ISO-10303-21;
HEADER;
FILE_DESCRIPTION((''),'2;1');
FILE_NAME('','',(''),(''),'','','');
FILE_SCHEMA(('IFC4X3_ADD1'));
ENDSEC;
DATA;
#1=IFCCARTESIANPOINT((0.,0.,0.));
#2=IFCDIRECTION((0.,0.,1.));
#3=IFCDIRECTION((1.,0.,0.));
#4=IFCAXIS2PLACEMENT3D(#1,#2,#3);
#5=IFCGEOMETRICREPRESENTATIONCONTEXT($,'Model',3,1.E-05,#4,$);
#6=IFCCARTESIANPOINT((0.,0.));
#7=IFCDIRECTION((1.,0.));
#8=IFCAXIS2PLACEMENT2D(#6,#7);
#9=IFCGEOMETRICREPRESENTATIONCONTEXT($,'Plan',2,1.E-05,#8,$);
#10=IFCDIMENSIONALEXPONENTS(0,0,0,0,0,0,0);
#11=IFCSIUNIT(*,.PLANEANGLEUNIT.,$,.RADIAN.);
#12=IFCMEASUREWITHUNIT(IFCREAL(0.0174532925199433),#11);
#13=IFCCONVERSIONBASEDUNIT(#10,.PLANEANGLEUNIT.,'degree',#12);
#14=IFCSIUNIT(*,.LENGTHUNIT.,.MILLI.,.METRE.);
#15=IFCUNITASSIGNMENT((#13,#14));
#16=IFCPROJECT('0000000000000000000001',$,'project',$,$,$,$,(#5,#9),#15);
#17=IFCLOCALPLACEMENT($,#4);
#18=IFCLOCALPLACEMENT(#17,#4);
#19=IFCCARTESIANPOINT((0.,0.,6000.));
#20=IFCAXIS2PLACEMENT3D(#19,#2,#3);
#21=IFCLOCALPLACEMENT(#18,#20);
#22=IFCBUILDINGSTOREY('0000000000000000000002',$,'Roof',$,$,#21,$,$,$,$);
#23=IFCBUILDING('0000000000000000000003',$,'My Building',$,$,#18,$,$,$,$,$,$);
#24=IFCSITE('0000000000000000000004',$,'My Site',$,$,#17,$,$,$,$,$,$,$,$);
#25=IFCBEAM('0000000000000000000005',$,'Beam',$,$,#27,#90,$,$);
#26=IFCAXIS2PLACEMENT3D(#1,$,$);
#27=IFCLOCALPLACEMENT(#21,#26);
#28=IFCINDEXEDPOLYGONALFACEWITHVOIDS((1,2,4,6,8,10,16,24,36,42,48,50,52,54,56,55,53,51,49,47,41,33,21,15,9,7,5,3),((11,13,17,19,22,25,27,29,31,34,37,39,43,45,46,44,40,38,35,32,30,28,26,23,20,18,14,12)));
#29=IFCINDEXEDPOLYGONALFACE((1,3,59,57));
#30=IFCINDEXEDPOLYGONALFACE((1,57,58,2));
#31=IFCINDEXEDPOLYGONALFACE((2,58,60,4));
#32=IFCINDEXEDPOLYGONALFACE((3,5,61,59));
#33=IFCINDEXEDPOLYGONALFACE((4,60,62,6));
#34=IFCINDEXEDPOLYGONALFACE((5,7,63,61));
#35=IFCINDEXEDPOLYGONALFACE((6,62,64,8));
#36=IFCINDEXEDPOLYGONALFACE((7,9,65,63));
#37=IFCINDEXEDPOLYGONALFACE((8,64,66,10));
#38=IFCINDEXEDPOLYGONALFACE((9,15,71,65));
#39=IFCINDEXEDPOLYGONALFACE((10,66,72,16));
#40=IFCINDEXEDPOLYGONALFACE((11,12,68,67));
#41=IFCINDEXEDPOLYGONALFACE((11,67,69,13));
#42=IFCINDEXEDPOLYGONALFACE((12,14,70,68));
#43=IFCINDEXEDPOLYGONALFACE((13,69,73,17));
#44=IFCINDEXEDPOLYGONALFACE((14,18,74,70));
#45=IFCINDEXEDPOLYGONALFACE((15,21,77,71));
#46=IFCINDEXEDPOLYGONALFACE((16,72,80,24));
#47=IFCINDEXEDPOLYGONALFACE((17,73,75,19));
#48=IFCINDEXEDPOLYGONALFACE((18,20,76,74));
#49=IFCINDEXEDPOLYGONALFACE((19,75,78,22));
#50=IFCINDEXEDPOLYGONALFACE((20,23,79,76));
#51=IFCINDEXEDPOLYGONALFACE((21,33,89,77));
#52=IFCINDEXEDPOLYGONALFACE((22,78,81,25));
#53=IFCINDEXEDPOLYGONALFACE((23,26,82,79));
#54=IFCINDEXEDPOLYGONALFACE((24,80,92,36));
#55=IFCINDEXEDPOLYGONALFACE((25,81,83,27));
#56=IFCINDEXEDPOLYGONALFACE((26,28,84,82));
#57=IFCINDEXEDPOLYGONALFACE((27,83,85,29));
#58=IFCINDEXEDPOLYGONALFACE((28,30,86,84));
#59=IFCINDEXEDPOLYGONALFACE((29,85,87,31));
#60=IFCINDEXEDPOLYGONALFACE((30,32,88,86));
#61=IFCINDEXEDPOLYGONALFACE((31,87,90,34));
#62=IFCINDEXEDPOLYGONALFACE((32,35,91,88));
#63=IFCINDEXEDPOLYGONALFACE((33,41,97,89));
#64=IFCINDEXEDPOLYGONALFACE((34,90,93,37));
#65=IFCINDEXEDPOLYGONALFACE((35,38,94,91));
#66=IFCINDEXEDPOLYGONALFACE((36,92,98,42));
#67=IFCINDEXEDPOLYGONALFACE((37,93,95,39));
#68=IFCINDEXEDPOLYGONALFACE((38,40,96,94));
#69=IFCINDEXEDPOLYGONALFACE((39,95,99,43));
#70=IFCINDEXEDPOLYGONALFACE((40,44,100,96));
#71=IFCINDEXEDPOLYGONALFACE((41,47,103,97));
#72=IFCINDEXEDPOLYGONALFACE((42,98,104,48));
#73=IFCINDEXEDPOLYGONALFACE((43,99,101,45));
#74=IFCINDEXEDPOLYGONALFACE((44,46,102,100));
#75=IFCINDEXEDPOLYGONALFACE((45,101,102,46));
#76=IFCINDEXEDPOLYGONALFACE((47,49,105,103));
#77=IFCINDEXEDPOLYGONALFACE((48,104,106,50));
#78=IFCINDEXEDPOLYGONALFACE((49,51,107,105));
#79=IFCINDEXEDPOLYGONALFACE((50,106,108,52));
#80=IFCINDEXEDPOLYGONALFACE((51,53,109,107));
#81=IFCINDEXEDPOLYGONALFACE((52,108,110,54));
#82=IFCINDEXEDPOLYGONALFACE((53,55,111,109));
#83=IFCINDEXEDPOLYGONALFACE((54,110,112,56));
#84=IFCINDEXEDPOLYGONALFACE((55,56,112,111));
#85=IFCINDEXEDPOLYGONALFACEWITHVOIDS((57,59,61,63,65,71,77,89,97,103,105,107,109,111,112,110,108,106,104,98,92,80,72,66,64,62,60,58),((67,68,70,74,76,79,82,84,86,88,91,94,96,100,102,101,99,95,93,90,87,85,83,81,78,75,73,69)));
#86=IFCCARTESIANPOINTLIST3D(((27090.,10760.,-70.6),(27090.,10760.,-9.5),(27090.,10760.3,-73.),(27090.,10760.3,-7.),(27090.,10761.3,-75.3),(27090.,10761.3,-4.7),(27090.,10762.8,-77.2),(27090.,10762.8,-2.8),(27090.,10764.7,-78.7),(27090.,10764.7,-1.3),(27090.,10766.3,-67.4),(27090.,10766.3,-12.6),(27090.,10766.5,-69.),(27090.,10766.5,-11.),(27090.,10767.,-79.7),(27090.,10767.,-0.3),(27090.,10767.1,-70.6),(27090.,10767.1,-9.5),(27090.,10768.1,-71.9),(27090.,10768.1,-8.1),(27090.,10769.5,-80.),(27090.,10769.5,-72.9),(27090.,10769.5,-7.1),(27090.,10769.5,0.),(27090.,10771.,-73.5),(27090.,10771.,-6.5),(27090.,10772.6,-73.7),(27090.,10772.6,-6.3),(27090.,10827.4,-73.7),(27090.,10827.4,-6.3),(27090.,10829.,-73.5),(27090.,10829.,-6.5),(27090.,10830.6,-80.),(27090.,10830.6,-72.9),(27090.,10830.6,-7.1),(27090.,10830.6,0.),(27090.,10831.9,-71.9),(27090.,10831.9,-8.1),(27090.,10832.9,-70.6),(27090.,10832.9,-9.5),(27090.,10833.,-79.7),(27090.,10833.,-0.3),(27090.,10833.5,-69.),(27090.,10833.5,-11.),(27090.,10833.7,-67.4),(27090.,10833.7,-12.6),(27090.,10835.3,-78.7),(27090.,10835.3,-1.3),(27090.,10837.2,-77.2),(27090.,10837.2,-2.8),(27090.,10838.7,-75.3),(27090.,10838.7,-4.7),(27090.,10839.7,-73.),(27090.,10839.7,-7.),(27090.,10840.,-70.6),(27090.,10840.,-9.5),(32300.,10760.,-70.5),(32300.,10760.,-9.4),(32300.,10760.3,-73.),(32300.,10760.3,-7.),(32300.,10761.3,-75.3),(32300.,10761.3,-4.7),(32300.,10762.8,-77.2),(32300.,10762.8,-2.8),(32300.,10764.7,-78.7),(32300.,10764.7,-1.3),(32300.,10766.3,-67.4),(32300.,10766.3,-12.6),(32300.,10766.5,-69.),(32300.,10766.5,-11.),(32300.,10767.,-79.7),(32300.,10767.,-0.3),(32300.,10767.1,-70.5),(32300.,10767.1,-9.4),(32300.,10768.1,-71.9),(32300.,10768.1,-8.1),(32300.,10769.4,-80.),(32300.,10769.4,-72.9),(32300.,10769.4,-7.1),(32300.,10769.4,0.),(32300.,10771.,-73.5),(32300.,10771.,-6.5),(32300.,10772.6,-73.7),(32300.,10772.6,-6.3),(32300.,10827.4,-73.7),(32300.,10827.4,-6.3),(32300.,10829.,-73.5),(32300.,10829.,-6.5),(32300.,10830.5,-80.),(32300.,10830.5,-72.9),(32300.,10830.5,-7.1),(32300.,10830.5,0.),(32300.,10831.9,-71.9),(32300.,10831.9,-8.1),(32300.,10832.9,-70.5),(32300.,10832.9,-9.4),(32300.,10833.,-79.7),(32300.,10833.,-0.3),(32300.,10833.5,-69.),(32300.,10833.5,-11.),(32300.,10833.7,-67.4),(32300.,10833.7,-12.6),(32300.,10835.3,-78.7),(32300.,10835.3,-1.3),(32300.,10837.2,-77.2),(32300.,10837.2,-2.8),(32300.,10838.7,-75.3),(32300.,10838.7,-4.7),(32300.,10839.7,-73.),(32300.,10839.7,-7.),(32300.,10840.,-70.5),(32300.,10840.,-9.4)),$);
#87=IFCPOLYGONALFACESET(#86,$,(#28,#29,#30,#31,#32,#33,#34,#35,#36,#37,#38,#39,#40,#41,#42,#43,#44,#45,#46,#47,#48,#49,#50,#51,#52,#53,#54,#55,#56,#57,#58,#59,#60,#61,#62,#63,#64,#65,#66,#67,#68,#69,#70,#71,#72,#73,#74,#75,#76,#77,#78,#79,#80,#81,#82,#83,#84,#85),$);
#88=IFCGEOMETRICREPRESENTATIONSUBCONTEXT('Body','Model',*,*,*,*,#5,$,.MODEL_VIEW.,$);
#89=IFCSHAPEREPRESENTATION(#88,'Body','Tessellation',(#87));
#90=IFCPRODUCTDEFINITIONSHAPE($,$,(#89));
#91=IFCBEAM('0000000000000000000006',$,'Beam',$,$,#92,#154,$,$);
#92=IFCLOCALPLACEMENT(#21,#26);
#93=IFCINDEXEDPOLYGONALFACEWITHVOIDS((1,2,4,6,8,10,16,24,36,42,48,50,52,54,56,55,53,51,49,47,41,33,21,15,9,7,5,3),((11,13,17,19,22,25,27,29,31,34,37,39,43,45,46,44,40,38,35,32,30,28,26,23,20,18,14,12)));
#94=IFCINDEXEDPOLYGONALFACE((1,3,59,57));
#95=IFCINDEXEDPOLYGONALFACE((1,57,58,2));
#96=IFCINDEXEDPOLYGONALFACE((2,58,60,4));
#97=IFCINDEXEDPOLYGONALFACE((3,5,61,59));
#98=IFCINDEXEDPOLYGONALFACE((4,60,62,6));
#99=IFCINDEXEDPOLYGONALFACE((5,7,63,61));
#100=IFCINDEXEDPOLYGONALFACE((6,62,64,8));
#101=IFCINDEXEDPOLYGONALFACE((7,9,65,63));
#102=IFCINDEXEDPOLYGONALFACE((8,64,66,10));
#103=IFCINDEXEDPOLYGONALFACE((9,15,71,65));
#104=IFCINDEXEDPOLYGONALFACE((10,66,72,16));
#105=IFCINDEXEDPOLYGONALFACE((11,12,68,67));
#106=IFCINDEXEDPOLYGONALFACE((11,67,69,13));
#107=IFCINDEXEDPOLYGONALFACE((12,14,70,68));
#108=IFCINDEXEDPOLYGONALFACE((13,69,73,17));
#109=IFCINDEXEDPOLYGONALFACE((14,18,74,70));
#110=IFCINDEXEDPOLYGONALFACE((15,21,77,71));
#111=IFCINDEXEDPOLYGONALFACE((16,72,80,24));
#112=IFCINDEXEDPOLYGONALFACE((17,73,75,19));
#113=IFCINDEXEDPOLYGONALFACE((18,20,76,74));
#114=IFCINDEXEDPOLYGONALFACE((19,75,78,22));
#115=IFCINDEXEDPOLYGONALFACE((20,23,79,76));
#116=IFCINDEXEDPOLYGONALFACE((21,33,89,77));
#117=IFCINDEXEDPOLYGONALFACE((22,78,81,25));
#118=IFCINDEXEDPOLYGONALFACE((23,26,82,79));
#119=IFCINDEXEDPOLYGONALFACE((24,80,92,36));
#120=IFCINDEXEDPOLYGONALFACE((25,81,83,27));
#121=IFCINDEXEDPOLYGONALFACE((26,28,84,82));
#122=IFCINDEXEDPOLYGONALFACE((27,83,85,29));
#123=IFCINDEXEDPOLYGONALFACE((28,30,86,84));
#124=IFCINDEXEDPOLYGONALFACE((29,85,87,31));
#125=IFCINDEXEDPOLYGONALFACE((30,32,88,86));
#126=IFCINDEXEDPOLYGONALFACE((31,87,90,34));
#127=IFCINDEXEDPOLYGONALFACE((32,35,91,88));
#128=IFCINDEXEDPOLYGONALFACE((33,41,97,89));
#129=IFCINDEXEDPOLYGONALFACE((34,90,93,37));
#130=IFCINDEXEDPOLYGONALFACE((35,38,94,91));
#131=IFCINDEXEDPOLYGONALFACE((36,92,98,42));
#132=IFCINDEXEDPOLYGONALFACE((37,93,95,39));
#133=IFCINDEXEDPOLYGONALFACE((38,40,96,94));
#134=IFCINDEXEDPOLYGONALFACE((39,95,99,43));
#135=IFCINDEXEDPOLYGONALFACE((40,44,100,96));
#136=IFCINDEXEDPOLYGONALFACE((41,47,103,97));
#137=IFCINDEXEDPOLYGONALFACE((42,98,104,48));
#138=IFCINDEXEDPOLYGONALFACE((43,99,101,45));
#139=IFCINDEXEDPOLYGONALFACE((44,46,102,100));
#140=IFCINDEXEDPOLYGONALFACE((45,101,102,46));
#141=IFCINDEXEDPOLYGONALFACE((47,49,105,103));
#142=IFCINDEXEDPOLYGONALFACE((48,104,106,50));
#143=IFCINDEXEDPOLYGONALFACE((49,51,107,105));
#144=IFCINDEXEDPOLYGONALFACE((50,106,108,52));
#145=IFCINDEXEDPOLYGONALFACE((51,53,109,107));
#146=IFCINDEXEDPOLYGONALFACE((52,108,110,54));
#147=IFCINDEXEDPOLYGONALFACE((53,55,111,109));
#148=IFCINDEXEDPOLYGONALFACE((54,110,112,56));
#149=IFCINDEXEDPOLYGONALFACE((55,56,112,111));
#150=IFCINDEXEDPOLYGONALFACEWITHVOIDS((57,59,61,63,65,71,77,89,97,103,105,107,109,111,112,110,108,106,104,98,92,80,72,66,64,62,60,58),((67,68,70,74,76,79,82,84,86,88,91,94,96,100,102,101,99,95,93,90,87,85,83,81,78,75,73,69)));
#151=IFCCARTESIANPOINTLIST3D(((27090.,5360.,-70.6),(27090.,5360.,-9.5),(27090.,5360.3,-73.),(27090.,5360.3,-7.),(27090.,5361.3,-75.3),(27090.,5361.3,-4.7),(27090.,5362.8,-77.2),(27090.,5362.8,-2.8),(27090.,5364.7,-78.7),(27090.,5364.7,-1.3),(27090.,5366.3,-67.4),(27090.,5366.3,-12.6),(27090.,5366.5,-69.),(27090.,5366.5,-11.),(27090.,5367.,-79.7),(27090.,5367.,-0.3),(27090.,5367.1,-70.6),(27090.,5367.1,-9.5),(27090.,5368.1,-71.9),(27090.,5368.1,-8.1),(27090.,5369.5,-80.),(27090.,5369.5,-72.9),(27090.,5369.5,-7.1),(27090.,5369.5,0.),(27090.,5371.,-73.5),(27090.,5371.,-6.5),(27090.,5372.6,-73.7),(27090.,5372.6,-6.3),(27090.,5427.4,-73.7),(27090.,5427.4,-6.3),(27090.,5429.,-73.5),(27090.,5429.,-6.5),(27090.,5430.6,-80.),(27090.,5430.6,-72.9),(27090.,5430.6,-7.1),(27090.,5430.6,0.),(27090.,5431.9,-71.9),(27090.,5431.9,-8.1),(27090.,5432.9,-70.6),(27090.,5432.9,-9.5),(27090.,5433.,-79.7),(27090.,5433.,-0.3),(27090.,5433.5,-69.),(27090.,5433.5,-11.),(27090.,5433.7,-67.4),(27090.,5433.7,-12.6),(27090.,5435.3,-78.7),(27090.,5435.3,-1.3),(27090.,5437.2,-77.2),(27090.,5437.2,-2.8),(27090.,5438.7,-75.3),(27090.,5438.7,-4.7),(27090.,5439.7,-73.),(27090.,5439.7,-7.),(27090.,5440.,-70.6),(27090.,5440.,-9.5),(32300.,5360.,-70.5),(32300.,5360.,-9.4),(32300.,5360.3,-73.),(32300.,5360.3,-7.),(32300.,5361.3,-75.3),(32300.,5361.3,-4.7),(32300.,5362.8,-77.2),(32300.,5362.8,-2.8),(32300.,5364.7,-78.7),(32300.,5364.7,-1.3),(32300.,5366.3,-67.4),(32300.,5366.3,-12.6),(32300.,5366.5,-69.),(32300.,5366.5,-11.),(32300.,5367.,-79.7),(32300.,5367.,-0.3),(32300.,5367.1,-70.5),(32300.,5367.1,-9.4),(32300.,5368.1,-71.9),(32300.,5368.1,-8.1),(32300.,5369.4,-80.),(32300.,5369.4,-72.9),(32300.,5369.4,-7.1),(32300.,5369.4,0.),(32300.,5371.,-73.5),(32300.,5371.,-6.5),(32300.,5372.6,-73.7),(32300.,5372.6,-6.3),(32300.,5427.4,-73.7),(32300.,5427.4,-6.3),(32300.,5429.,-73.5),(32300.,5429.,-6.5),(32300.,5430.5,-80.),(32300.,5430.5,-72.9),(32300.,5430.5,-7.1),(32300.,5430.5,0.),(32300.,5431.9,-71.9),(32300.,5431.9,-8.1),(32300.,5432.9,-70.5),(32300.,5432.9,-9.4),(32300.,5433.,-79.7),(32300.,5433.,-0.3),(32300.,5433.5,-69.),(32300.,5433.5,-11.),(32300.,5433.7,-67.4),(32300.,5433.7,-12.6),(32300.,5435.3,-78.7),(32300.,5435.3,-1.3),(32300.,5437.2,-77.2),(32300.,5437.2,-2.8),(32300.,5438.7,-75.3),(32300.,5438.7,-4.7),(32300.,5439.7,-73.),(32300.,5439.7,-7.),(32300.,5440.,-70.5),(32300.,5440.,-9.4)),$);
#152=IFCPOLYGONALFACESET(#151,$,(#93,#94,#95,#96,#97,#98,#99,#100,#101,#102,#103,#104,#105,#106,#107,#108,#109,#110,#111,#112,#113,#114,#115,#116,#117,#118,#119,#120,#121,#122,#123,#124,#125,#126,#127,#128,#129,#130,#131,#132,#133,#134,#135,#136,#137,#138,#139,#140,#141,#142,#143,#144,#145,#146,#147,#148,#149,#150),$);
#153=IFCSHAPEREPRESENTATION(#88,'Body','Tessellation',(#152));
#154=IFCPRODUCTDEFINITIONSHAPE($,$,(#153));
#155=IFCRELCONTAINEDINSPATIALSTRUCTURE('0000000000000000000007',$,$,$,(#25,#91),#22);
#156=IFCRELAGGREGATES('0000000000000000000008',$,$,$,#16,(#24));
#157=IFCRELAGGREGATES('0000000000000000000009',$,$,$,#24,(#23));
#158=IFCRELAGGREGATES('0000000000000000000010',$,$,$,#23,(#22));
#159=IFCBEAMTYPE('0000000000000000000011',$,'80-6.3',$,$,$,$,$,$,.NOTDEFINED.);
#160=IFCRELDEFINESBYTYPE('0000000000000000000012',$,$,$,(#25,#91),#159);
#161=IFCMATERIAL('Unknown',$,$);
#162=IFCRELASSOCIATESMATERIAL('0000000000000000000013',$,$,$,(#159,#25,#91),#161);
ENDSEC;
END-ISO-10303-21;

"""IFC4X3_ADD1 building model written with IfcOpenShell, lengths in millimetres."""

from ifc_helpers import new_model, entity, si_unit, converted_unit, frame, origin_with_axes, origin_2d_with_axis, place, context, subcontext, project, spatial, hollow_rectangle, extrude, material, material_profile, profile_set, profile_usage, type_object, element, save


model = new_model("IFC4X3_ADD1")

# Units and contexts
model_context = context("Model", 3, precision=1e-05, world=origin_with_axes())
plan_context = context("Plan", 2, precision=1e-05, world=origin_2d_with_axis())
body_context = subcontext(model_context, "Body", "Model", "MODEL_VIEW")
ifc_project = project(units=[converted_unit("PLANEANGLEUNIT", "degree", entity("IfcReal", 0.0174532925199433), si_unit("PLANEANGLEUNIT", "RADIAN"), dimensions=[0, 0, 0, 0, 0, 0, 0]), si_unit("LENGTHUNIT", "METRE", prefix="MILLI")], contexts=[model_context, plan_context])

# Site, building, storey
site_placement = place(None, origin_with_axes())
site = spatial("IfcSite", under=ifc_project, at=site_placement, Name="My Site")
building_placement = place(site_placement, origin_with_axes())
building = spatial("IfcBuilding", under=site, at=building_placement, Name="My Building")
storey_placement = place(building_placement, frame((0.0, 0.0, 6000.0), z_axis=(0.0, 0.0, 1.0), x_axis=(1.0, 0.0, 0.0)))
storey = spatial("IfcBuildingStorey", under=building, at=storey_placement, Name="Roof")

# Beams
ifc_material = material(Name="Unknown")
ifc_material_profile_1 = material_profile(ifc_material, hollow_rectangle(XDim=80.0, YDim=80.0, WallThickness=6.3, InnerFilletRadius=6.3, OuterFilletRadius=9.4))
ifc_profile_set_1 = profile_set([ifc_material_profile_1])
beam_type_1 = type_object("IfcBeamType", Name="80-6.3", PredefinedType="NOTDEFINED", material=ifc_profile_set_1)
ifc_profile_usage_1 = profile_usage(ifc_profile_set_1, cardinal=8)
beam_1_placement = place(storey_placement, frame((27090.0, 10800.0, 0.0), z_axis=(1.0, 0.0, 0.0), x_axis=(0.0, 1.0, 0.0)))
element("IfcBeam", 1, at=beam_1_placement, inside=storey, type_object=beam_type_1, material=ifc_profile_usage_1, Name="Beam", context=body_context, shape_type="SweptSolid", body=[
    extrude(hollow_rectangle(XDim=80.0, YDim=80.0, WallThickness=6.3, InnerFilletRadius=6.3, OuterFilletRadius=9.4), frame((0.0, -40.0, 0.0), z_axis=(0.0, 0.0, 1.0), x_axis=(1.0, 0.0, 0.0)), (0.0, 0.0, 1.0), 5210.0),
])
ifc_profile_usage_2 = profile_usage(ifc_profile_set_1, cardinal=8)
beam_2_placement = place(storey_placement, frame((27090.0, 5400.0, 0.0), z_axis=(1.0, 0.0, 0.0), x_axis=(0.0, 1.0, 0.0)))
element("IfcBeam", 2, at=beam_2_placement, inside=storey, type_object=beam_type_1, material=ifc_profile_usage_2, Name="Beam", context=body_context, shape_type="SweptSolid", body=[
    extrude(hollow_rectangle(XDim=80.0, YDim=80.0, WallThickness=6.3, InnerFilletRadius=6.3, OuterFilletRadius=9.4), frame((0.0, -40.0, 0.0), z_axis=(0.0, 0.0, 1.0), x_axis=(1.0, 0.0, 0.0)), (0.0, 0.0, 1.0), 5210.0),
])

save(model, "model.ifc")
